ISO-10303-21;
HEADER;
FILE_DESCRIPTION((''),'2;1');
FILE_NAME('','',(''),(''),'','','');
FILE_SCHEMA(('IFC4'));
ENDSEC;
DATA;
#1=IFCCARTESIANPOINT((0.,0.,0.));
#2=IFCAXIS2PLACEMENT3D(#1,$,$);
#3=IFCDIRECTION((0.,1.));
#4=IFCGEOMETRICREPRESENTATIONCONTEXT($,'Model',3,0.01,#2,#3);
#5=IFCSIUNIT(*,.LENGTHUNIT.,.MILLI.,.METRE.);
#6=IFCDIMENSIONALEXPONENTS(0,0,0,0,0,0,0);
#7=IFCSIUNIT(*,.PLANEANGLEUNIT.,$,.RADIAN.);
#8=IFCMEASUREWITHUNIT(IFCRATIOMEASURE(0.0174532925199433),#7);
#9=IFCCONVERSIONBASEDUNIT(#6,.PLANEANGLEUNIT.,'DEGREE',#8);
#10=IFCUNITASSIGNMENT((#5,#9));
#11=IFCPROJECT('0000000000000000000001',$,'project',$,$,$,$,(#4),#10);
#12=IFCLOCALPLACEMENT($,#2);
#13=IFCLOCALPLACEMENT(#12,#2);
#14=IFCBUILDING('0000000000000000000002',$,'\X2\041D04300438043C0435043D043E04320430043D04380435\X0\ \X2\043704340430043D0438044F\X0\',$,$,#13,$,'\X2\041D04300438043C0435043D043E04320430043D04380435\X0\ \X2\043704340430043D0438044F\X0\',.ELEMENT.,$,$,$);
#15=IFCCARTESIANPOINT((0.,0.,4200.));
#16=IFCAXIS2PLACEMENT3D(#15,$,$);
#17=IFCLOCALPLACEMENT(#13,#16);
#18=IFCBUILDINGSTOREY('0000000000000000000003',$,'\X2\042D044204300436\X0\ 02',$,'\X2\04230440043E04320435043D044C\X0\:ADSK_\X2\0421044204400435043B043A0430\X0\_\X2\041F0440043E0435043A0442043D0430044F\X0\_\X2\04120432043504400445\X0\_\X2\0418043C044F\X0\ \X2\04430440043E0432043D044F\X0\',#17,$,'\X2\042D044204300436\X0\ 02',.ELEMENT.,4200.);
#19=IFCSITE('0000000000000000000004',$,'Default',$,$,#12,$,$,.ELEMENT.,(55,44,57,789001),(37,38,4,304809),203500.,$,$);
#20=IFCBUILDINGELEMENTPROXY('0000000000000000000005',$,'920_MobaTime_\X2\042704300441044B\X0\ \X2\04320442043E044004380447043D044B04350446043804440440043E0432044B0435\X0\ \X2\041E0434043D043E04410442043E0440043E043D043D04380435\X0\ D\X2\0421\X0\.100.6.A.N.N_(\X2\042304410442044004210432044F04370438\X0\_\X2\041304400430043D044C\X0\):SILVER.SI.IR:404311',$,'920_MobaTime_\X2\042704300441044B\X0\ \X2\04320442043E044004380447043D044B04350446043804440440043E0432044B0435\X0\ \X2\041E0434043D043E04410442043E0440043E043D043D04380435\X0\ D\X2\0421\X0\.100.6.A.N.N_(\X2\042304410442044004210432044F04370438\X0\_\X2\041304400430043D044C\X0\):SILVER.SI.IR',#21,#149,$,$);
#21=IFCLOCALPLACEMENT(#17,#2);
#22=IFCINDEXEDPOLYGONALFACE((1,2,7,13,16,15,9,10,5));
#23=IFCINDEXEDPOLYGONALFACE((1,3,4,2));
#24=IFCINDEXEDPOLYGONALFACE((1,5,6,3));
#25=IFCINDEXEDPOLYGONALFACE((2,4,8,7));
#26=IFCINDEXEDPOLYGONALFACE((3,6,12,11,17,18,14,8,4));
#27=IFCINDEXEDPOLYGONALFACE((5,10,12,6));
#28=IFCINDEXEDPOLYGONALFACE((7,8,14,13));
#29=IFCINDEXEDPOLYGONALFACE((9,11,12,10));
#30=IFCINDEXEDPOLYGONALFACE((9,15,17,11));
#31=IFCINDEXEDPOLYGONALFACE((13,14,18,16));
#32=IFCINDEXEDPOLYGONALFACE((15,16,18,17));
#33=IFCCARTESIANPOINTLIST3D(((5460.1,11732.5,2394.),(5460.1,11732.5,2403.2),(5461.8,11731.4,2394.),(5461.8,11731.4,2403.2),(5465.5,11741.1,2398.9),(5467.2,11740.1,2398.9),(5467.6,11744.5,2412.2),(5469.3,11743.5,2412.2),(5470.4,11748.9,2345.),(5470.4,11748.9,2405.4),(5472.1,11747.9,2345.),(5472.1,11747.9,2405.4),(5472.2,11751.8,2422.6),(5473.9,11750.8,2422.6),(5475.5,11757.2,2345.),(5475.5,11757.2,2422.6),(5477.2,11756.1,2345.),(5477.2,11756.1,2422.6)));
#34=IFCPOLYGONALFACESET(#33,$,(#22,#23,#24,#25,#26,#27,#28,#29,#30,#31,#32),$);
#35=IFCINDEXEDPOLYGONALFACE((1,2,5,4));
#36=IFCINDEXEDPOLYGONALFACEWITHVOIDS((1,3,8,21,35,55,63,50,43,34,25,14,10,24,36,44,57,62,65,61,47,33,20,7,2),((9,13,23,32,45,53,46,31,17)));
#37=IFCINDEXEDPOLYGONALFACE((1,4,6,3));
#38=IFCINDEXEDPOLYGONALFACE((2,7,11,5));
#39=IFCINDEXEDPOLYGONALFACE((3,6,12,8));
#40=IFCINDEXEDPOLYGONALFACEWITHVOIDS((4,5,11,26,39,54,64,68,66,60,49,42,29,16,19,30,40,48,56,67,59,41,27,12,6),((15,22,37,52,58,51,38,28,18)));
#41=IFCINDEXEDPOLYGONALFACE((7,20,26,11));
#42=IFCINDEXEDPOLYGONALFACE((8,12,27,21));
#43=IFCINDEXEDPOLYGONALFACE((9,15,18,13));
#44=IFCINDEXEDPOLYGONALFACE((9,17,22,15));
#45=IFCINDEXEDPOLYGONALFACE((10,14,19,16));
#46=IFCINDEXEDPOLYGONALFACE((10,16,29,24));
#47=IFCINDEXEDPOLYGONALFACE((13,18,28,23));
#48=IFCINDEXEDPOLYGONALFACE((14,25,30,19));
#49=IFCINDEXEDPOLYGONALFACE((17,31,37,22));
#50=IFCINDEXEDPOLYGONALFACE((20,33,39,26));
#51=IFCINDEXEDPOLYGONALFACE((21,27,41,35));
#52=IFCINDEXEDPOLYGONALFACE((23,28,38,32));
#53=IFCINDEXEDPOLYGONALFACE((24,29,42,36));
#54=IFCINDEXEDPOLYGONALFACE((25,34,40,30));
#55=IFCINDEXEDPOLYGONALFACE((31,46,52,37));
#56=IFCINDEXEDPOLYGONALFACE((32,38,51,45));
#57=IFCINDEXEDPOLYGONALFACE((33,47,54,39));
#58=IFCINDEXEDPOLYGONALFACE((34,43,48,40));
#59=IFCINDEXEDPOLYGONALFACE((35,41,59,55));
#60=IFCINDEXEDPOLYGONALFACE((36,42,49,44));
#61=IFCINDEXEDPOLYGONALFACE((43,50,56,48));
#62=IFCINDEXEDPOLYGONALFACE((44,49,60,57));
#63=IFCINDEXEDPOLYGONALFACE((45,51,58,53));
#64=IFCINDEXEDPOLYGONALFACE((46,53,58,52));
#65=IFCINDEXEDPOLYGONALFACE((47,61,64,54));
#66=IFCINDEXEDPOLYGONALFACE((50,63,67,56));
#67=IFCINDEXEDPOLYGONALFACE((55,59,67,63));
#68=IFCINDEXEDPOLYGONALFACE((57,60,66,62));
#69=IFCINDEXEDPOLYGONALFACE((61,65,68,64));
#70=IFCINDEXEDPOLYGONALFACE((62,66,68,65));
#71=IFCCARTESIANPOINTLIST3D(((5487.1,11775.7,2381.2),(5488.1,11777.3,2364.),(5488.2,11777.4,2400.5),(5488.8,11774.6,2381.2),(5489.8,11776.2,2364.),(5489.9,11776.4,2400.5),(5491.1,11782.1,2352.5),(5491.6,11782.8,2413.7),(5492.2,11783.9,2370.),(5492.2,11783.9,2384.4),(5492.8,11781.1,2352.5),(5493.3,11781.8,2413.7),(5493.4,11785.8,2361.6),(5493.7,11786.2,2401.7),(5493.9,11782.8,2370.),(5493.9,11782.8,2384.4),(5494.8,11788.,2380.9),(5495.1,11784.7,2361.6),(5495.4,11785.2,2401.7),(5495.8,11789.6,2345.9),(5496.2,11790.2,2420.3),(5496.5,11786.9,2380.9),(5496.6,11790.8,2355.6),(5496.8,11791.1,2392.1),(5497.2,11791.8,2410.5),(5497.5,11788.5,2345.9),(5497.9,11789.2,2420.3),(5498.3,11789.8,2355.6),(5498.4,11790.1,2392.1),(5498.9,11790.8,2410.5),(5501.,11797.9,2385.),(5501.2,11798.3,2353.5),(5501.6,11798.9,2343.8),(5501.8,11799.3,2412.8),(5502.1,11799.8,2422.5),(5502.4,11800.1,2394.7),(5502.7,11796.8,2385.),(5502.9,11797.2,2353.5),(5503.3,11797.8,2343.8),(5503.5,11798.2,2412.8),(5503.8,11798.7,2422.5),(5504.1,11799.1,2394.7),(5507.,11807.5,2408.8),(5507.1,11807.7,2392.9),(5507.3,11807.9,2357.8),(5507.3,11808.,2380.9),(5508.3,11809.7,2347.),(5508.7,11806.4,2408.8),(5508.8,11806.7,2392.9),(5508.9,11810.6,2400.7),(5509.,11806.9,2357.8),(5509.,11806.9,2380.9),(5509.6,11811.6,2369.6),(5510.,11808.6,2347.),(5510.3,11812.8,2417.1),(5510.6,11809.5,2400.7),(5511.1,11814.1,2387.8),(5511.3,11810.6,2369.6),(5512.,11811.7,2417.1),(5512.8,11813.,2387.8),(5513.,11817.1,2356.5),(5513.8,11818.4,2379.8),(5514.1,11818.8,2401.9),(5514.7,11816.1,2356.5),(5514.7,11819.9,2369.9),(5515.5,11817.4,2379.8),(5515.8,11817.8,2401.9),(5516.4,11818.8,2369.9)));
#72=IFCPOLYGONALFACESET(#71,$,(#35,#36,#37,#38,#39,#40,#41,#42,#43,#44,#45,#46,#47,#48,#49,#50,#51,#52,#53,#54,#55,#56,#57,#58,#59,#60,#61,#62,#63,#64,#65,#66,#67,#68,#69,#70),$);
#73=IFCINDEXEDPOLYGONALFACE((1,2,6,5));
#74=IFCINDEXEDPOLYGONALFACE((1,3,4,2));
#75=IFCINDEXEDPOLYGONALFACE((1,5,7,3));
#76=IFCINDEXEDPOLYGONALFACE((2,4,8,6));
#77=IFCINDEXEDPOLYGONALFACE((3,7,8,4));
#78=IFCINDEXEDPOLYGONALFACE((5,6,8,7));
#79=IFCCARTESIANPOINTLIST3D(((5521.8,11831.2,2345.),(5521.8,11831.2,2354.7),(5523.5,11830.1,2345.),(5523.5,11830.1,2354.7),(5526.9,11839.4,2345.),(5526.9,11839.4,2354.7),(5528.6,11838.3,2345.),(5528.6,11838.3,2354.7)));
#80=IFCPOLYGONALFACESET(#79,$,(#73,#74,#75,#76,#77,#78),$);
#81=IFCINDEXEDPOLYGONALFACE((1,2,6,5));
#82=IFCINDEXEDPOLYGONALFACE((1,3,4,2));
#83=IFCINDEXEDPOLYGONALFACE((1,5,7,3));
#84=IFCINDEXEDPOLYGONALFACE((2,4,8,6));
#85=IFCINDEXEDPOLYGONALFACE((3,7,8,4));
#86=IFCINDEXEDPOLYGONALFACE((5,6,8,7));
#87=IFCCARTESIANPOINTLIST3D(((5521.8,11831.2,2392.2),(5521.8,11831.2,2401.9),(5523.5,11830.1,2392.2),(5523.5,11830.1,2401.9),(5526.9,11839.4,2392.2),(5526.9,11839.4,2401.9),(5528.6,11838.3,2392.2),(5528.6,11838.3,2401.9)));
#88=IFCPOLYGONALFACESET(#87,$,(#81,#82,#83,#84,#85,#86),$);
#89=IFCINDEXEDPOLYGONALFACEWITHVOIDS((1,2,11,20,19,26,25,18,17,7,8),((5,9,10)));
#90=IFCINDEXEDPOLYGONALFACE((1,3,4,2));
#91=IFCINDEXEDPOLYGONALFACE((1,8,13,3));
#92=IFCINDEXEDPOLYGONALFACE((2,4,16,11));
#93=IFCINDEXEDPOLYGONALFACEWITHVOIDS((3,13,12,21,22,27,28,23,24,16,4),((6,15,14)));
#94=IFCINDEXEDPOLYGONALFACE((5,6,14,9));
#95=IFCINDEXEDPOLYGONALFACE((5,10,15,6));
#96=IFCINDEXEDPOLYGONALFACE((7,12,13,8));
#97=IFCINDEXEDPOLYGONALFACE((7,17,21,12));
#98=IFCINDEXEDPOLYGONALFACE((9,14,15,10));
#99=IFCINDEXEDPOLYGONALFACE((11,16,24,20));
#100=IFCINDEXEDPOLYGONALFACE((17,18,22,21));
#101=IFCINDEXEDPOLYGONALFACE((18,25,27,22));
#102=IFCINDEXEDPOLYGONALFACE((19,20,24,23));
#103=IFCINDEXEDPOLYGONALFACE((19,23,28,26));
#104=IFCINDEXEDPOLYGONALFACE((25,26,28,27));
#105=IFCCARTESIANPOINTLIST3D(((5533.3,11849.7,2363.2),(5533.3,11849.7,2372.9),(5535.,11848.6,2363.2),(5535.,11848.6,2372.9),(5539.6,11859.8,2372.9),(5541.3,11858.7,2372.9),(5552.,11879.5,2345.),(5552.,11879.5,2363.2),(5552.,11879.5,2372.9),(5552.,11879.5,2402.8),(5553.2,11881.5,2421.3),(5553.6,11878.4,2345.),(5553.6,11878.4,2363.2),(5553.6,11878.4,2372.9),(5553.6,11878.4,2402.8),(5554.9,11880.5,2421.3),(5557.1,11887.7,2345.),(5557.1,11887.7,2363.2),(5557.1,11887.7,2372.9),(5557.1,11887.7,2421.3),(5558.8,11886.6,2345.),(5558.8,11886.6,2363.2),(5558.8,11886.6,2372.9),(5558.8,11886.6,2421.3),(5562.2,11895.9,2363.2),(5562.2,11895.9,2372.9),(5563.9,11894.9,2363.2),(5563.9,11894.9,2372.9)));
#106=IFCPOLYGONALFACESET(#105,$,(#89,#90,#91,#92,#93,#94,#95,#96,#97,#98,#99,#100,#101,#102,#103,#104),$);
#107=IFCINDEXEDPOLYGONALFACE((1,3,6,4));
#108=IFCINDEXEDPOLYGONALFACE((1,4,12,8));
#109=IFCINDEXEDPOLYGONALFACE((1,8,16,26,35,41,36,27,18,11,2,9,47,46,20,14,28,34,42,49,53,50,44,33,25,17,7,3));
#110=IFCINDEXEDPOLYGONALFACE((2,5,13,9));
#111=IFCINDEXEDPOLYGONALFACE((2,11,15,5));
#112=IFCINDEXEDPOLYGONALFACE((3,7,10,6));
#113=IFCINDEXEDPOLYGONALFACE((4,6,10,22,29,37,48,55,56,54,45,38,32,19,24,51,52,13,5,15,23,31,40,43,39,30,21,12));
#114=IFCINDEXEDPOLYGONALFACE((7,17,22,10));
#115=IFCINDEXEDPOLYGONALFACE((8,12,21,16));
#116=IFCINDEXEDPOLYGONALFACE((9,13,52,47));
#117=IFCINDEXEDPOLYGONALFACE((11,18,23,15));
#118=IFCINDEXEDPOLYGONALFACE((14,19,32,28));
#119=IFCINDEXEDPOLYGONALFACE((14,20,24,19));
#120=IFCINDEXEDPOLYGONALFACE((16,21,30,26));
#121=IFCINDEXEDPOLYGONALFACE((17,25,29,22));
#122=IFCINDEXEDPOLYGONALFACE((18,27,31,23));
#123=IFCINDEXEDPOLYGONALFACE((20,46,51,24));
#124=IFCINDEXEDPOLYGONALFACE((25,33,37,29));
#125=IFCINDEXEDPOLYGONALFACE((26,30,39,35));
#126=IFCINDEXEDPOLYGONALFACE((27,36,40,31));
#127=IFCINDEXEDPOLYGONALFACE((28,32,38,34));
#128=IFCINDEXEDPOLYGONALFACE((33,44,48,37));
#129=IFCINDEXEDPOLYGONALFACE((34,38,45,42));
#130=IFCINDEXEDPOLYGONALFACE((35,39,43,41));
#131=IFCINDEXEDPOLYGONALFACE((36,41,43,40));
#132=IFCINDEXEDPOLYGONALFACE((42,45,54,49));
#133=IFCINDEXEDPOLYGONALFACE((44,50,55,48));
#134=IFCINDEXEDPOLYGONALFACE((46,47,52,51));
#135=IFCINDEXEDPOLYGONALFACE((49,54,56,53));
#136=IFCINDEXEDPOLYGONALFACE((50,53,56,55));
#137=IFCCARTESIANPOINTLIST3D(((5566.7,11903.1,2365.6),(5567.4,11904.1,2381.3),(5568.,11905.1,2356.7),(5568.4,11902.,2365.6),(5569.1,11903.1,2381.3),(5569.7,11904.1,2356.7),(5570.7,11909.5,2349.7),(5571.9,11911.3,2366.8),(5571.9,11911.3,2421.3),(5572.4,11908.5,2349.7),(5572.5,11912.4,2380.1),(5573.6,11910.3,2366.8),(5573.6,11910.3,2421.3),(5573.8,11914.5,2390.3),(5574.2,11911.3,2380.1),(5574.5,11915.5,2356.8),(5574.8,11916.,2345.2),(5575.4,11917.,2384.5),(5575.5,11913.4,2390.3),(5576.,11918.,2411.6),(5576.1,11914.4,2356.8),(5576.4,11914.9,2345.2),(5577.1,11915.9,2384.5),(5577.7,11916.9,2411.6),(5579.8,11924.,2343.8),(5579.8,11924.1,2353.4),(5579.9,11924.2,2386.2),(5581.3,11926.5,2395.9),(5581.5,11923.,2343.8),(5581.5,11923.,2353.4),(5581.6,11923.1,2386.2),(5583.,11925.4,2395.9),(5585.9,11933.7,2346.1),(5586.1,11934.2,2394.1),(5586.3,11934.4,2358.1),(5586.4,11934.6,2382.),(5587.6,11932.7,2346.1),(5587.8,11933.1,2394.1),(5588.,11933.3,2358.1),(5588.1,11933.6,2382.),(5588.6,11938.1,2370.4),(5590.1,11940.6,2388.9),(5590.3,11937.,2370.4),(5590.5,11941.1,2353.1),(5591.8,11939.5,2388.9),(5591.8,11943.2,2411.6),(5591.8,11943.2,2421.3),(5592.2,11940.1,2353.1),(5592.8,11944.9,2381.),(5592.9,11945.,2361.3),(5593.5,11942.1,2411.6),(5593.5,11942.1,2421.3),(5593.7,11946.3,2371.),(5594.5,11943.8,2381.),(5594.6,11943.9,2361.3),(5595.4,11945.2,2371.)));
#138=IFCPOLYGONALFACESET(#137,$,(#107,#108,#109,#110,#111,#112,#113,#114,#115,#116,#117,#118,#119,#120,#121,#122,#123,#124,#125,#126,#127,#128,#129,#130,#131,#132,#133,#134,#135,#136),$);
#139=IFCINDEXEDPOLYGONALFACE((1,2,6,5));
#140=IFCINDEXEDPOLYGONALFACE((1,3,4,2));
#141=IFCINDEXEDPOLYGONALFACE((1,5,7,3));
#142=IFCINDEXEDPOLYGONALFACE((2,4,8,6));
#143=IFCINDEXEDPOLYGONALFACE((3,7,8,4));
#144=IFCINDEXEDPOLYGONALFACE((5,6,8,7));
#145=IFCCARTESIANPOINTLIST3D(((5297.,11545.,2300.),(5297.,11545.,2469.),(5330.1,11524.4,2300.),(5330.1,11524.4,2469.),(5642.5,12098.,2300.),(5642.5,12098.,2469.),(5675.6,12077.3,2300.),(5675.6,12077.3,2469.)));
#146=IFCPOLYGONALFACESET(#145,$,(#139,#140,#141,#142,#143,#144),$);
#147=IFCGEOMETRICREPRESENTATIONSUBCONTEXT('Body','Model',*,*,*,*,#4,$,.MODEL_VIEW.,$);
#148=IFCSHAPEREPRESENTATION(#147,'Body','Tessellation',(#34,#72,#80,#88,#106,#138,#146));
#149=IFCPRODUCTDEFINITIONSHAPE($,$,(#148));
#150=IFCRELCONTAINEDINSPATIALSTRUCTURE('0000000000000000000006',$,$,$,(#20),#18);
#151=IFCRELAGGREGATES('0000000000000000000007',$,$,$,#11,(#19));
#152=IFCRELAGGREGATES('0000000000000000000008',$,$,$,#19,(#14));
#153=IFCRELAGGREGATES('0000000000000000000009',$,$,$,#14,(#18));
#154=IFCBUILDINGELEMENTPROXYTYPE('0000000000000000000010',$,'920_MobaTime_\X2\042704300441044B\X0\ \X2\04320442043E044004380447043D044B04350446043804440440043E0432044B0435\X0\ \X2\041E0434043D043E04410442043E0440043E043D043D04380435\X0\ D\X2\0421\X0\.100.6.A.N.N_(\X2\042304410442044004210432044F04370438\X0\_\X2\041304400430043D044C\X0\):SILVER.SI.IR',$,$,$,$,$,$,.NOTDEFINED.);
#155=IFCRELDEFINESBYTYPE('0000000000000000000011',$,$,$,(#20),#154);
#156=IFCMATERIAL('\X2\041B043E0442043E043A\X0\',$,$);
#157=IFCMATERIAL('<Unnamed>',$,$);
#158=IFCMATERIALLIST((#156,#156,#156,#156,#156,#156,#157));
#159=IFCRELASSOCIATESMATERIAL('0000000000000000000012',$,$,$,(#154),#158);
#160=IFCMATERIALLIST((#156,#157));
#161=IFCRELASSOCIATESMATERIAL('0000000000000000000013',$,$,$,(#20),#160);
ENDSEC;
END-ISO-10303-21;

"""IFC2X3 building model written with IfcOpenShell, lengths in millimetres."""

from ifc_helpers import new_model, entity, si_unit, converted_unit, direction, frame, origin, origin_2d_with_axis, place, context, subcontext, project, spatial, polyline, rectangle, outline, extrude, source, transform, mapped, material, material_list, type_object, type_shapes, element, save


model = new_model("IFC2X3")

# Units and contexts
model_context = context("Model", 3, precision=0.01, world=origin(), true_north=direction((0.0, 1.0)))
body_context = subcontext(model_context, "Body", "Model", "MODEL_VIEW")
ifc_project = project(units=[si_unit("LENGTHUNIT", "METRE", prefix="MILLI"), converted_unit("PLANEANGLEUNIT", "DEGREE", entity("IfcRatioMeasure", 0.0174532925199433), si_unit("PLANEANGLEUNIT", "RADIAN"), dimensions=[0, 0, 0, 0, 0, 0, 0])], contexts=[model_context])

# Site, building, storey
site_placement = place(None, origin())
site = spatial("IfcSite", under=ifc_project, at=site_placement, Name="Default", CompositionType="ELEMENT", RefLatitude=(55, 44, 57, 789001), RefLongitude=(37, 38, 4, 304809), RefElevation=203500.0)
building_placement = place(site_placement, origin())
building = spatial("IfcBuilding", under=site, at=building_placement, Name="Наименование здания", LongName="Наименование здания", CompositionType="ELEMENT")
storey_placement = place(building_placement, frame((0.0, 0.0, 4200.0)))
storey = spatial("IfcBuildingStorey", under=building, at=storey_placement, Name="Этаж 02", ObjectType="Уровень:ADSK_Стрелка_Проектная_Вверх_Имя уровня", LongName="Этаж 02", CompositionType="ELEMENT", Elevation=4200.0)

# Building element proxy
ifc_material_1 = material(Name="Лоток")
ifc_material_2 = material(Name="<Unnamed>")
ifc_material_list_1 = material_list([ifc_material_1, ifc_material_2])
ifc_material_list_2 = material_list([ifc_material_1, ifc_material_1, ifc_material_1, ifc_material_1, ifc_material_1, ifc_material_1, ifc_material_2])
building_element_proxy_type_1 = type_object("IfcBuildingElementProxyType", Name="920_MobaTime_Часы вторичныецифровые Односторонние DС.100.6.A.N.N_(УстрСвязи_Грань):SILVER.SI.IR", PredefinedType="NOTDEFINED", material=ifc_material_list_2)
shared_shape_1 = source(origin(), body_context, "Body", "SweptSolid", [
    extrude(outline(polyline([(-49.3, -13.1), (28.2, -13.1), (28.2, -6.8), (17.9, 1.8), (8.8, 16.0), (-0.3, 16.0), (4.6, 5.8), (11.1, -3.4), (-49.3, -3.4), (-49.3, -13.1)])), frame((-64.6, 9.8, 39.0), z_axis=(0.0, 0.0, 1.0), x_axis=(0.0, 1.0, 0.0)), (0.0, 0.0, 1.0), 2.0),
    extrude(outline(polyline([(2.2, -27.6), (19.0, -27.6), (30.5, -16.1), (33.3, -4.9), (31.0, 5.8), (21.8, 17.2), (5.2, 27.3), (-11.1, 33.0), (-24.0, 32.7), (-33.6, 27.6), (-40.3, 18.6), (-42.8, 5.7), (-38.0, -6.3), (-27.2, -14.9), (-17.5, -17.7), (-8.2, -16.4), (-0.3, -11.9), (5.1, -4.5), (7.3, 6.2), (4.0, 17.2), (18.4, 7.3), (23.6, -2.4), (22.0, -11.4), (14.2, -18.4), (5.3, -18.3), (2.2, -27.6)]), holes=[polyline([(-9.0, 23.3), (-1.3, 14.3), (-2.5, 2.0), (-11.4, -7.0), (-23.4, -6.0), (-32.2, 2.9), (-31.2, 15.1), (-25.6, 22.1), (-17.5, 24.9), (-9.0, 23.3)])]), frame((-2.7, 3.6, 39.0), z_axis=(0.0, 0.0, 1.0), x_axis=(-0.427649, 0.903945, 0.0)), (0.0, 0.0, 1.0), 2.0),
    extrude(rectangle(XDim=9.7, YDim=9.7, at=origin_2d_with_axis()), frame((40.6, -34.7, 39.0)), (0.0, 0.0, 1.0), 2.0),
    extrude(rectangle(XDim=9.7, YDim=9.7, at=origin_2d_with_axis()), frame((40.6, 12.6, 39.0)), (0.0, 0.0, 1.0), 2.0),
    extrude(outline(polyline([(-0.9, -28.1), (8.8, -28.1), (8.8, -9.9), (18.5, -9.9), (18.5, -0.2), (8.8, -0.2), (8.8, 48.3), (1.5, 48.3), (-36.0, -0.2), (-36.0, -9.9), (-0.9, -9.9), (-0.9, -28.1)]), holes=[polyline([(-0.9, -0.2), (-24.1, -0.2), (-0.9, 29.7), (-0.9, -0.2)])]), frame((93.6, -11.4, 39.0)), (0.0, 0.0, 1.0), 2.0),
    extrude(outline(polyline([(3.3, -28.3), (12.5, -28.3), (20.5, -25.0), (26.8, -18.9), (30.7, -10.0), (31.4, 1.6), (26.9, 11.8), (20.1, 18.4), (11.1, 22.3), (1.0, 23.3), (-7.9, 20.4), (-14.9, 14.5), (-18.9, 6.2), (-17.1, -9.0), (-36.7, 0.5), (-29.1, 29.2), (-38.5, 31.7), (-48.1, -4.6), (-11.6, -23.1), (-8.0, -14.0), (-10.8, -7.6), (-10.2, 1.1), (-3.0, 11.8), (9.2, 12.8), (20.0, 5.5), (21.4, -7.5), (15.5, -16.4), (4.6, -18.6), (3.3, -28.3)])), frame((147.1, -8.5, 39.0), z_axis=(0.0, 0.0, 1.0), x_axis=(0.256974, -0.966418, 0.0)), (0.0, 0.0, 1.0), 2.0),
    extrude(rectangle(XDim=652.0, YDim=169.0, at=origin_2d_with_axis()), frame((0.0, 0.0, 0.0), z_axis=(0.0, 0.0, 1.0), x_axis=(-1.0, 0.0, 0.0)), (0.0, 0.0, 1.0), 39.0),
])
type_shapes(building_element_proxy_type_1, [shared_shape_1])
for number, where, z_axis, x_axis, name in (
    (1, (5469.7, 11821.5, 2384.5), (0.848048, -0.529919, 0.0), (0.529919, 0.848048, 0.0), "920_MobaTime_Часы вторичныецифровые Односторонние DС.100.6.A.N.N_(УстрСвязи_Грань):SILVER.SI.IR:404311"),
):
    element("IfcBuildingElementProxy", number, at=place(storey_placement, frame(where, z_axis=z_axis, x_axis=x_axis)), inside=storey, type_object=building_element_proxy_type_1, material=ifc_material_list_1, Name=name, ObjectType="920_MobaTime_Часы вторичныецифровые Односторонние DС.100.6.A.N.N_(УстрСвязи_Грань):SILVER.SI.IR", context=body_context, shape_type="MappedRepresentation", body=[
        mapped(shared_shape_1, transform((0.0, 0.0, 0.0), scale=1.0)),
    ])

save(model, "model.ifc")
